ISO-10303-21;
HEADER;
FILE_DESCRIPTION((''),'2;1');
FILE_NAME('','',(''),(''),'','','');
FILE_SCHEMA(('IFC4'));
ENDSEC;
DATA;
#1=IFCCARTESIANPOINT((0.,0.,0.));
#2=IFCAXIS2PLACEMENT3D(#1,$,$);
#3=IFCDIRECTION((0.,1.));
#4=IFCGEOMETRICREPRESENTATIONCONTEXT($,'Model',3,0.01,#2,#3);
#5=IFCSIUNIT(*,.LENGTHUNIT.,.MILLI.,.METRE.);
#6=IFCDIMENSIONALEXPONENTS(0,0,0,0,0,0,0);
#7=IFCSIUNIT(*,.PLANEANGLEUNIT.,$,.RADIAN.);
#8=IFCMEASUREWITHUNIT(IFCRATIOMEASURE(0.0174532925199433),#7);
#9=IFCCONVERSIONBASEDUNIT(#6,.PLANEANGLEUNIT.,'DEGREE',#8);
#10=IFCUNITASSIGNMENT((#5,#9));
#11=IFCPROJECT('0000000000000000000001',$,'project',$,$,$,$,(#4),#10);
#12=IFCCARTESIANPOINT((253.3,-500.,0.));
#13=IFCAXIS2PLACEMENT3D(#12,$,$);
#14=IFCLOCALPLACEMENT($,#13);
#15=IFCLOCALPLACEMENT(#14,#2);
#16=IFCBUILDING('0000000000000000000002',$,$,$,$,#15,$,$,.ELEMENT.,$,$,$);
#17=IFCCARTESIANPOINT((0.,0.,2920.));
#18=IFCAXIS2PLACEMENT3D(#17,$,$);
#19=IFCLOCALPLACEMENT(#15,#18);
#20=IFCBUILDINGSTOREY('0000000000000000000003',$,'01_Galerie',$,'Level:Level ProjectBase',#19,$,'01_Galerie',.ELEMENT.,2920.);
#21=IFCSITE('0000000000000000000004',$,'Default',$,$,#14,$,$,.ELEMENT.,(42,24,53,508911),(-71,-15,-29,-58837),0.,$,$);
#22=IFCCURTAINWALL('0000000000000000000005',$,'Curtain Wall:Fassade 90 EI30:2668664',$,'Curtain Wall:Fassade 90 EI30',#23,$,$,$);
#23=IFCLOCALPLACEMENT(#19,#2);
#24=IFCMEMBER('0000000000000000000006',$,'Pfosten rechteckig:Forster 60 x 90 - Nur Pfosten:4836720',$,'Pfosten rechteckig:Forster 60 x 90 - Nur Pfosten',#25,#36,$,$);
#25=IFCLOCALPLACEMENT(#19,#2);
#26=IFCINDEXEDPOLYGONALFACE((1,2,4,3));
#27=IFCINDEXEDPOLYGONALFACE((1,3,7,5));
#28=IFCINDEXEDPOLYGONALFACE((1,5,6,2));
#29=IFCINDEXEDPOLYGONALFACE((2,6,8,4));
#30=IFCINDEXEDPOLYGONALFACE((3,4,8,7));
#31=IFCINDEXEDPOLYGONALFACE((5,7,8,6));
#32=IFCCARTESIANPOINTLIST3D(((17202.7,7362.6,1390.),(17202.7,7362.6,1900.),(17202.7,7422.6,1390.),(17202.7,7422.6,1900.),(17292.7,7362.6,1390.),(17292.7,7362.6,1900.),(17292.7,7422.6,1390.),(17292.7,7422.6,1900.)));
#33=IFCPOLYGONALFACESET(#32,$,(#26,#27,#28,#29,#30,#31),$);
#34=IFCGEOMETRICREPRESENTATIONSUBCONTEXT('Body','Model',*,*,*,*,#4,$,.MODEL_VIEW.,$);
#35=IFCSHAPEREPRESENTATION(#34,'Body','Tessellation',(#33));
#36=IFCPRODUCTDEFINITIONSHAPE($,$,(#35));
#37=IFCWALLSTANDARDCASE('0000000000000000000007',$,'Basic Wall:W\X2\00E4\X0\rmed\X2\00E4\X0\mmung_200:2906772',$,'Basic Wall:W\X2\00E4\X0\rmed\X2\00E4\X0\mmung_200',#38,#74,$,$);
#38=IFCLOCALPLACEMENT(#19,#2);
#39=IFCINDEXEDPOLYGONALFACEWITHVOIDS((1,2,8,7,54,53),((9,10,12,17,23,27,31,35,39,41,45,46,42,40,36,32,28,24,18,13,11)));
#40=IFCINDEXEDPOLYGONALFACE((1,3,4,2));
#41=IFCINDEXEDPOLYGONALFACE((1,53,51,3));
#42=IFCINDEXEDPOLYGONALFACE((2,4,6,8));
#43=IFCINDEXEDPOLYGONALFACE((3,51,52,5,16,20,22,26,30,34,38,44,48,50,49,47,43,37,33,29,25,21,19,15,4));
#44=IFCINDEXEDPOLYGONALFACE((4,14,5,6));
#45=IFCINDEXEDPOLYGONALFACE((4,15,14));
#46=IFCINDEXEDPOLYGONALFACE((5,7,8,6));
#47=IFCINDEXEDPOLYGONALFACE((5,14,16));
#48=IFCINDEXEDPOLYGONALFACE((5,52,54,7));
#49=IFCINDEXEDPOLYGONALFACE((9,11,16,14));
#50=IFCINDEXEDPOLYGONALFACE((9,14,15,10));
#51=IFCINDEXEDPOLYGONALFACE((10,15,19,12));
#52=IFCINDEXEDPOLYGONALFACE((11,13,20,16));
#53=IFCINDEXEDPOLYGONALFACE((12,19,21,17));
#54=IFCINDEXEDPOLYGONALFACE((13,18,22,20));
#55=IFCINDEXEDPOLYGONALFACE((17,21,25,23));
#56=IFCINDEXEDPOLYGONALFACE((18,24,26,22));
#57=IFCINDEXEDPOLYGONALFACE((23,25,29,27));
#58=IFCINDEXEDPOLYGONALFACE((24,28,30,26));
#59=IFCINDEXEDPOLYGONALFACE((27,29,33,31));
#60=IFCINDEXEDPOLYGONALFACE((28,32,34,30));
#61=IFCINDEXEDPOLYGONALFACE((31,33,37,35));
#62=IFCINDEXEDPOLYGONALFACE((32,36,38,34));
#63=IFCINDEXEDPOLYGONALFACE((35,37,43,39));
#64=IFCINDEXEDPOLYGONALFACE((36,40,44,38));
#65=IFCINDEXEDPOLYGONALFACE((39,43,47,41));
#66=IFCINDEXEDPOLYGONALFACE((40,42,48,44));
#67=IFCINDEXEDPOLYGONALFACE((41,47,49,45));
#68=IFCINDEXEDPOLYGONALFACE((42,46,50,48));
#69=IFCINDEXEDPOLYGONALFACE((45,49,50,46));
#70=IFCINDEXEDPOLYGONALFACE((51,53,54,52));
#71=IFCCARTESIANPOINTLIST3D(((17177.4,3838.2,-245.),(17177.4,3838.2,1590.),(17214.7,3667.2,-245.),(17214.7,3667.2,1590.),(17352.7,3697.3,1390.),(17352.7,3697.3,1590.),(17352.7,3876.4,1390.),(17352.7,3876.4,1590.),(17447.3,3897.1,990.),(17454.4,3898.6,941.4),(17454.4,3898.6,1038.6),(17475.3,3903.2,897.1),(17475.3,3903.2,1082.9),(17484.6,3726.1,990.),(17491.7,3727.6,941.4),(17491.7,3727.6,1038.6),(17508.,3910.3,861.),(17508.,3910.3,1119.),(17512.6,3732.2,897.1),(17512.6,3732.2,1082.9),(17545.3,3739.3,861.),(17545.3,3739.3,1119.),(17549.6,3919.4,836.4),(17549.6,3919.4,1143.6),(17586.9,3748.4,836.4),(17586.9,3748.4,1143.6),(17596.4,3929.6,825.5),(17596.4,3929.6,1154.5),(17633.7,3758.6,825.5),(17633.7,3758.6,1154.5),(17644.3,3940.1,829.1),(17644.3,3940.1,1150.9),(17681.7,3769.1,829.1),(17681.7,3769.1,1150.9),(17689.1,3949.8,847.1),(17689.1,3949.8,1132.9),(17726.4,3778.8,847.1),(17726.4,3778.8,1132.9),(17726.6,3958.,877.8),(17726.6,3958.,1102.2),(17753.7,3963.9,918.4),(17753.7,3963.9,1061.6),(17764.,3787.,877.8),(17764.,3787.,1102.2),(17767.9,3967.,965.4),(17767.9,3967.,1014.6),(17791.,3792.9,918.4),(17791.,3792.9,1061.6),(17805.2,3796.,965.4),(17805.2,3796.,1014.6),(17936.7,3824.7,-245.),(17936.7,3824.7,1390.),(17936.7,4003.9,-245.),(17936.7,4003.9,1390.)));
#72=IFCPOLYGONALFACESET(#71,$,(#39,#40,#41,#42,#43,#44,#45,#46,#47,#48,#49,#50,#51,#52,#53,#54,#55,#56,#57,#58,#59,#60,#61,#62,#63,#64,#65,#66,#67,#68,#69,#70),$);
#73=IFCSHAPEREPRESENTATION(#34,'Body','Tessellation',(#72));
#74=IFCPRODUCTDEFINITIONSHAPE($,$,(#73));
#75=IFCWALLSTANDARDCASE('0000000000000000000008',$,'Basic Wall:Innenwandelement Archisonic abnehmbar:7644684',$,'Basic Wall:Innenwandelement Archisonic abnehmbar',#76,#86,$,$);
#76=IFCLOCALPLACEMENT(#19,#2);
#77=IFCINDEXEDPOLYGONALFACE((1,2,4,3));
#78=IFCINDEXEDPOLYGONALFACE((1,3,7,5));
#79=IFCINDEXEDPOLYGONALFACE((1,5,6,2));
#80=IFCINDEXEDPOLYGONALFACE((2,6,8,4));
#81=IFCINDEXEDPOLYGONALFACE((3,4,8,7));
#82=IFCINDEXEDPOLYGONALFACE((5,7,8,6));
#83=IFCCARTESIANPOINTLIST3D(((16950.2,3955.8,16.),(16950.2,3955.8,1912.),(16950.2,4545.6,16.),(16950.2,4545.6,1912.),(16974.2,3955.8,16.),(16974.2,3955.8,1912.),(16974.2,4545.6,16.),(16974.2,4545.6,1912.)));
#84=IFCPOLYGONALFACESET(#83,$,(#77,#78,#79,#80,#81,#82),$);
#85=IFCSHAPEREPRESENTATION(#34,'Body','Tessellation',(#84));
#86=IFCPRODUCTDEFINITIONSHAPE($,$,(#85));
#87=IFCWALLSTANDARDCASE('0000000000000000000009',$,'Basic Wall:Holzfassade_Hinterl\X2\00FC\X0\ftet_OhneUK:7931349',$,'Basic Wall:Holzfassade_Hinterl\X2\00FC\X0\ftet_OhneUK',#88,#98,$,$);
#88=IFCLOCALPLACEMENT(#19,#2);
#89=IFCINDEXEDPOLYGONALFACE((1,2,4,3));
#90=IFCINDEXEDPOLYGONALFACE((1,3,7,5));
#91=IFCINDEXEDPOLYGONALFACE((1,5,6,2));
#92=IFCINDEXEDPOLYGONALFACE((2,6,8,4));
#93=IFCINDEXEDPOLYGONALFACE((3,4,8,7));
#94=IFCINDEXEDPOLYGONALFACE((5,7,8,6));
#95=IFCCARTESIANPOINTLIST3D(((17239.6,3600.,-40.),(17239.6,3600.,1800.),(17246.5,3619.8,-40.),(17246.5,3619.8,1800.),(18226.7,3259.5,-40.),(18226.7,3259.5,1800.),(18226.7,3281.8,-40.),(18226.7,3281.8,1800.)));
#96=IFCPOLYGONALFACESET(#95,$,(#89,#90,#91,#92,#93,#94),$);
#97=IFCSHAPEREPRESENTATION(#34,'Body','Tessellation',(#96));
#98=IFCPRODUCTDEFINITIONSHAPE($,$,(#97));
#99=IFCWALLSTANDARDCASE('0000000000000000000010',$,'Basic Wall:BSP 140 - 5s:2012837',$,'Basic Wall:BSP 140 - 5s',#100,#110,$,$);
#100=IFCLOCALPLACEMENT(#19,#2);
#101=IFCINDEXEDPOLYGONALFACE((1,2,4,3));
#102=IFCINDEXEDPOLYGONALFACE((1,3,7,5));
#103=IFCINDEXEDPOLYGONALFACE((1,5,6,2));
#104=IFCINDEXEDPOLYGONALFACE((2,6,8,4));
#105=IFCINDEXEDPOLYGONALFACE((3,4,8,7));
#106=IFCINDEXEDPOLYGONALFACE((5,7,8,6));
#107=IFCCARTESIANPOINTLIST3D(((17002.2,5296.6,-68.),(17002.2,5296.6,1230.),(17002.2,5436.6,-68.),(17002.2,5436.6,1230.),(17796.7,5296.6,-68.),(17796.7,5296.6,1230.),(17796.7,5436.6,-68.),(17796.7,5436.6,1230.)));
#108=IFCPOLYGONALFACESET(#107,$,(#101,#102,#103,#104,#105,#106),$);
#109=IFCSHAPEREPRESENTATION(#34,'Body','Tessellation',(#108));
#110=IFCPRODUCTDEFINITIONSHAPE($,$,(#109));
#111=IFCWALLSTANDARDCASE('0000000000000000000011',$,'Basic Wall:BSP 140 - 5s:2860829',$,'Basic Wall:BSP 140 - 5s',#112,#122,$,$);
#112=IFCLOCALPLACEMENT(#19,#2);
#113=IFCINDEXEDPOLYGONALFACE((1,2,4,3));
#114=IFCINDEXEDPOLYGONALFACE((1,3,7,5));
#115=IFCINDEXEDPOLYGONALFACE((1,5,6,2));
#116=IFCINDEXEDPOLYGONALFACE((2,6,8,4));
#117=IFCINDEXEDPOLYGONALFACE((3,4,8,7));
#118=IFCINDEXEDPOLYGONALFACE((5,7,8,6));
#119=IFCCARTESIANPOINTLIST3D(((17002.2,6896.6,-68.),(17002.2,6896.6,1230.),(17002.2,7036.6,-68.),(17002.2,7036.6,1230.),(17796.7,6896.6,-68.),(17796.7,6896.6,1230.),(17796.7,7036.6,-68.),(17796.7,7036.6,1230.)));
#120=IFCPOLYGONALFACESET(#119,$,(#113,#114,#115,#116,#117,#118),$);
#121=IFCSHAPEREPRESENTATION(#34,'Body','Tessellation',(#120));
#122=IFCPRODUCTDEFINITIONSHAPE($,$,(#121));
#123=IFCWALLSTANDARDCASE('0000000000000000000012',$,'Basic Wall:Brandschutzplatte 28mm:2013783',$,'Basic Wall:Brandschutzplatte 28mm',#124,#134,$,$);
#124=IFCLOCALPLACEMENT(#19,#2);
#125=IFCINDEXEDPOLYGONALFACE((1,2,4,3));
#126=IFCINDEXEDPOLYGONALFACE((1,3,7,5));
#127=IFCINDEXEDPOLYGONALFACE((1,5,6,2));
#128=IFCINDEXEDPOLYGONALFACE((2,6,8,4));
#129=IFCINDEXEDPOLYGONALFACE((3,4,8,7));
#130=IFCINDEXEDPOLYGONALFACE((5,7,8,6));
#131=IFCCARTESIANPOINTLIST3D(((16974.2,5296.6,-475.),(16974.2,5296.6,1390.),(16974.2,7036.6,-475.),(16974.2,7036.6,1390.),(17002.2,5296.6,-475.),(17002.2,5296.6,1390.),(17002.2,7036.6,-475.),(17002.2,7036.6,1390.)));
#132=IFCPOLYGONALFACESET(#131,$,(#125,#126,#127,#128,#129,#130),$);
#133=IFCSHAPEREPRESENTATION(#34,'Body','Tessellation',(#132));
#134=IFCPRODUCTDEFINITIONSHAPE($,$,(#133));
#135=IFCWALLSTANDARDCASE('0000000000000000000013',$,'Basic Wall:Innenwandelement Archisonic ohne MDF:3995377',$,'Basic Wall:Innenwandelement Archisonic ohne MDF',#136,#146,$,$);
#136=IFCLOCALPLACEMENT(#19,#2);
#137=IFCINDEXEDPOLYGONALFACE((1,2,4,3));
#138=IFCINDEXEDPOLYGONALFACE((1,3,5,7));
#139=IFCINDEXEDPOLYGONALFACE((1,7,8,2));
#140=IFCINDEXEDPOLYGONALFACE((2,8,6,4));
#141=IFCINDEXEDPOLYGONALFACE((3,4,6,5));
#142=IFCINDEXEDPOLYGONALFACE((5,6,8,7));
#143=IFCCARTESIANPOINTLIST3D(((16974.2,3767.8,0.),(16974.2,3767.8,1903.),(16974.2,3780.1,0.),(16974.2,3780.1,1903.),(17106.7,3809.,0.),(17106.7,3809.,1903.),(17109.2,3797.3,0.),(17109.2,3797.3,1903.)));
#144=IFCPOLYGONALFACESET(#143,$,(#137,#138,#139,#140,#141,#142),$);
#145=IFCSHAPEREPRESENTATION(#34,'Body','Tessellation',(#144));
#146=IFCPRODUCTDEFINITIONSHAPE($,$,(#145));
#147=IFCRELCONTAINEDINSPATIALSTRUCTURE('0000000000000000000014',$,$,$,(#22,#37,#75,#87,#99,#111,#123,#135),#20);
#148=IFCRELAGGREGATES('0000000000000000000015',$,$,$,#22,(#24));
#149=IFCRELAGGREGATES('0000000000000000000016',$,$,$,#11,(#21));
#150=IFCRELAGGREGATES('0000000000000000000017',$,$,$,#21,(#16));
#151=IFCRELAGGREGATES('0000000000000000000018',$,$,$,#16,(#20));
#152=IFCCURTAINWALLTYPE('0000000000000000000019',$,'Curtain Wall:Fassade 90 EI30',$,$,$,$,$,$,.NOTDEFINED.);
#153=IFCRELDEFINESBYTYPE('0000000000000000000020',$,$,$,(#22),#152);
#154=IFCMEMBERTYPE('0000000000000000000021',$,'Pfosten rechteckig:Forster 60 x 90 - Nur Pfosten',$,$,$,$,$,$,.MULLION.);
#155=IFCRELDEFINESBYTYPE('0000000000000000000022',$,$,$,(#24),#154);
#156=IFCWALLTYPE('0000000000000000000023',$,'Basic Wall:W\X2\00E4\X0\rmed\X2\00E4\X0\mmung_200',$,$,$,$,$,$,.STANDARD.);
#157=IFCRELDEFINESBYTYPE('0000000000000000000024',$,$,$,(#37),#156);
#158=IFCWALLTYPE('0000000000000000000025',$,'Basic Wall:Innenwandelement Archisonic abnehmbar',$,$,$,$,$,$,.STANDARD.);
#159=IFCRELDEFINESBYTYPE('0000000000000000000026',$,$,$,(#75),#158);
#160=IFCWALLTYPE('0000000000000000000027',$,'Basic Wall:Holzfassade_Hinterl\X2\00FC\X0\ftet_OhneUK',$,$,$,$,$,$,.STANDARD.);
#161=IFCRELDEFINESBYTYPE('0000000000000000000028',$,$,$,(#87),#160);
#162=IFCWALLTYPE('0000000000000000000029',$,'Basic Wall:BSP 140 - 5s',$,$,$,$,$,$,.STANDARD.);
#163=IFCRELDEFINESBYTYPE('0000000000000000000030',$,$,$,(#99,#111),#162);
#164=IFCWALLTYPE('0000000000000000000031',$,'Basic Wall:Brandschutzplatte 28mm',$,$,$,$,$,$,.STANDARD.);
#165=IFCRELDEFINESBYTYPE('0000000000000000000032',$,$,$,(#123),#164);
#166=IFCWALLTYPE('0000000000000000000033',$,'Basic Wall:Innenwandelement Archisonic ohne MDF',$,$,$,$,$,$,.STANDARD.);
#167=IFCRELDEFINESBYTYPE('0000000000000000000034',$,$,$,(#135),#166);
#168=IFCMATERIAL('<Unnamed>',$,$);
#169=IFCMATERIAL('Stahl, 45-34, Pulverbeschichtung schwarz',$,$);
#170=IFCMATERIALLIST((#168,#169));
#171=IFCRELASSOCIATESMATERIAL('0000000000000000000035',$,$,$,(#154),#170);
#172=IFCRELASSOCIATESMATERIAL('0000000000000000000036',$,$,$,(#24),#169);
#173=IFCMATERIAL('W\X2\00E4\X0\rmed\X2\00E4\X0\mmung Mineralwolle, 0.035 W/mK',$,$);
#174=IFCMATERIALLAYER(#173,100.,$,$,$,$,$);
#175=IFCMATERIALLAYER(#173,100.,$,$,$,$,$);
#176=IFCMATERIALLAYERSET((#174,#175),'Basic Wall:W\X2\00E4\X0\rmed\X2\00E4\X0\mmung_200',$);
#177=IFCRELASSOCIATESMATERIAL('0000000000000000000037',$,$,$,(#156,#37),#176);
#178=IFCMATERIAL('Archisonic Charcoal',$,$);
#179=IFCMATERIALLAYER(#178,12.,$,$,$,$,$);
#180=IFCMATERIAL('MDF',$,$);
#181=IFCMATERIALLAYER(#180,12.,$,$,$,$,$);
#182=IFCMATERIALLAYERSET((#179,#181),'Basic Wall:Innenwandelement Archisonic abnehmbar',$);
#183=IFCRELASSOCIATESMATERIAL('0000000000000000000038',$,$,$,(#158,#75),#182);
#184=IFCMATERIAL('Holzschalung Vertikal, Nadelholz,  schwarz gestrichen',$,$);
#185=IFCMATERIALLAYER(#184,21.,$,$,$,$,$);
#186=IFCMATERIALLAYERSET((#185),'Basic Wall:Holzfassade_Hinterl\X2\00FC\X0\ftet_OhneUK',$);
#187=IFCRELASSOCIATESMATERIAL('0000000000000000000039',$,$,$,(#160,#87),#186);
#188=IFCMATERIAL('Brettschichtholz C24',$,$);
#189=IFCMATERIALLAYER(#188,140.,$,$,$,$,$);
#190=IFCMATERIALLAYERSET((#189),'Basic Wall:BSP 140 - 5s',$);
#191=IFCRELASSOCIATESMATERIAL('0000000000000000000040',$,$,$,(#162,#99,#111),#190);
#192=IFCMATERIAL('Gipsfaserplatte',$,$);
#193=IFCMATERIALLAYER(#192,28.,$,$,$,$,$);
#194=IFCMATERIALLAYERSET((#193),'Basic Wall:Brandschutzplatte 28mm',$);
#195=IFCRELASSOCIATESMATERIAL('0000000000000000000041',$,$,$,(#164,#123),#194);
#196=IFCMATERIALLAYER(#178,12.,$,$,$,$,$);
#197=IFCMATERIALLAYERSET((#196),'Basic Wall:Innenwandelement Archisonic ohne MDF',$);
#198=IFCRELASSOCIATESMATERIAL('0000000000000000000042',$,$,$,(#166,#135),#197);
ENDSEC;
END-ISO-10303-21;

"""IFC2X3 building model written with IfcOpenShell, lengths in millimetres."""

from ifc_helpers import new_model, entity, si_unit, converted_unit, direction, frame, frame_2d, origin, origin_2d_with_axis, place, context, subcontext, project, spatial, polyline, rectangle, circle, outline, extrude, clip, bounded_halfspace, source, transform, mapped, material, material_list, layer, layer_set, layer_usage, type_object, type_shapes, element, aggregate, save


model = new_model("IFC2X3")

# Units and contexts
model_context = context("Model", 3, precision=0.01, world=origin(), true_north=direction((0.0, 1.0)))
body_context = subcontext(model_context, "Body", "Model", "MODEL_VIEW")
ifc_project = project(units=[si_unit("LENGTHUNIT", "METRE", prefix="MILLI"), converted_unit("PLANEANGLEUNIT", "DEGREE", entity("IfcRatioMeasure", 0.0174532925199433), si_unit("PLANEANGLEUNIT", "RADIAN"), dimensions=[0, 0, 0, 0, 0, 0, 0])], contexts=[model_context])

# Site, building, storey
site_placement = place(None, frame((253.3, -500.0, 0.0)))
site = spatial("IfcSite", under=ifc_project, at=site_placement, Name="Default", CompositionType="ELEMENT", RefLatitude=(42, 24, 53, 508911), RefLongitude=(-71, -15, -29, -58837), RefElevation=0.0)
building_placement = place(site_placement, origin())
building = spatial("IfcBuilding", under=site, at=building_placement, CompositionType="ELEMENT")
storey_placement = place(building_placement, frame((0.0, 0.0, 2920.0)))
storey = spatial("IfcBuildingStorey", under=building, at=storey_placement, Name="01_Galerie", ObjectType="Level:Level ProjectBase", LongName="01_Galerie", CompositionType="ELEMENT", Elevation=2920.0)

# Curtain wall, member
curtain_wall_type = type_object("IfcCurtainWallType", Name="Curtain Wall:Fassade 90 EI30", PredefinedType="NOTDEFINED")
curtain_wall_placement = place(storey_placement, frame((0.0, 0.0, -2920.0)))
curtain_wall = element("IfcCurtainWall", 1, at=curtain_wall_placement, inside=storey, type_object=curtain_wall_type, Name="Curtain Wall:Fassade 90 EI30:2668664", ObjectType="Curtain Wall:Fassade 90 EI30")
ifc_material_1 = material(Name="Stahl, 45-34, Pulverbeschichtung schwarz")
ifc_material_2 = material(Name="<Unnamed>")
ifc_material_list = material_list([ifc_material_2, ifc_material_1])
member_type = type_object("IfcMemberType", Name="Pfosten rechteckig:Forster 60 x 90 - Nur Pfosten", PredefinedType="MULLION", material=ifc_material_list)
shared_shape_1 = source(origin(), body_context, "Body", "SweptSolid", [
    extrude(rectangle(XDim=90.0, YDim=60.0, at=origin_2d_with_axis()), frame((0.0, 79.0, -510.0), z_axis=(0.0, 0.0, 1.0), x_axis=(0.0, -1.0, 0.0)), (0.0, 0.0, 1.0), 510.0),
])
type_shapes(member_type, [shared_shape_1])
member_placement = place(storey_placement, frame((17326.7, 7392.6, 1390.0), z_axis=(0.0, 0.0, -1.0), x_axis=(0.0, -1.0, 0.0)))
member = element("IfcMember", 2, at=member_placement, type_object=member_type, material=ifc_material_1, Name="Pfosten rechteckig:Forster 60 x 90 - Nur Pfosten:4836720", ObjectType="Pfosten rechteckig:Forster 60 x 90 - Nur Pfosten", context=body_context, shape_type="MappedRepresentation", body=[
    mapped(shared_shape_1, transform((0.0, 0.0, 0.0), scale=1.0)),
])
aggregate(curtain_wall, [member])

# Wall, openings
ifc_material_3 = material(Name="Wärmedämmung Mineralwolle, 0.035 W/mK")
ifc_layer_1 = layer(ifc_material_3, 100.0)
ifc_layer_2 = layer(ifc_material_3, 100.0)
ifc_layer_set_1 = layer_set([ifc_layer_1, ifc_layer_2], Name="Basic Wall:Wärmedämmung_200")
ifc_layer_usage_1 = layer_usage(ifc_layer_set_1, "AXIS2", "NEGATIVE", 100.0)
wall_type_1 = type_object("IfcWallType", Name="Basic Wall:Wärmedämmung_200", PredefinedType="STANDARD", material=ifc_layer_set_1)
wall_1_placement = place(storey_placement, frame((17958.0, 3906.2, -245.0), z_axis=(0.0, 0.0, 1.0), x_axis=(-0.977008, -0.213201, 0.0)))
wall_1 = element("IfcWallStandardCase", 3, at=wall_1_placement, inside=storey, type_object=wall_type_1, material=ifc_layer_usage_1, Name="Basic Wall:Wärmedämmung_200:2906772", ObjectType="Basic Wall:Wärmedämmung_200", context=body_context, shape_type="Clipping", body=[
    clip(clip(clip(clip(extrude(outline(polyline([(777.1, -100.0), (777.1, 75.0), (38.2, 75.1), (0.0, -100.0), (777.1, -100.0)])), origin(), (0.0, 0.0, 1.0), 1835.0), bounded_halfspace(frame((777.1, 75.0, 0.0), z_axis=(-0.000101, -1.0, 0.0), x_axis=(1.0, -0.000101, 0.0)), True, frame((777.1, 75.0, 0.0), z_axis=(-0.000101, -1.0, 0.0), x_axis=(1.0, -0.000101, 0.0)), polyline([(0.0, 0.0), (0.0, 245.0), (-738.9, 245.0), (-738.9, 0.0), (0.0, 0.0)]))), bounded_halfspace(frame((43.6, 100.0, 245.0), z_axis=(0.0, 0.0, 1.0), x_axis=(-0.000101, -1.0, 0.0)), True, frame((43.6, 100.0, 245.0), z_axis=(0.0, 0.0, 1.0), x_axis=(-0.000101, -1.0, 0.0)), polyline([(0.0, 0.0), (24.9, -5.4), (24.9, 733.5), (-0.1, 733.5), (0.0, 0.0)]))), bounded_halfspace(frame((597.7, -100.0, 1635.0), z_axis=(0.0, 0.0, -1.0), x_axis=(-0.835636, -0.549284, 0.0)), True, frame((597.7, -100.0, 1635.0), z_axis=(0.0, 0.0, -1.0), x_axis=(-0.835636, -0.549284, 0.0)), polyline([(0.0, 0.0), (499.5, 328.3), (353.2, 471.5), (-146.3, 143.2), (0.0, 0.0)]))), bounded_halfspace(frame((641.4, 100.0, 1635.0), z_axis=(0.977008, -0.213201, 0.0), x_axis=(0.0, 0.0, 1.0)), True, frame((641.4, 100.0, 1635.0), z_axis=(0.977008, -0.213201, 0.0), x_axis=(0.0, 0.0, 1.0)), polyline([(0.0, 0.0), (200.0, 0.0), (200.0, 204.7), (0.0, 204.7), (0.0, 0.0)]))),
])
opening_1_placement = place(wall_1_placement, frame((608.3, 120.5, 1068.4)))
element("IfcOpeningElement", 4, at=opening_1_placement, cuts=wall_1, ObjectType="Opening", context=body_context, shape_type="SweptSolid", body=[
    extrude(circle(Radius=165.0, at=frame_2d((0.0, 0.0), x_axis=(1.0, 0.0))), frame((-272.4, -484.5, 166.6), z_axis=(0.0, 1.0, 0.0), x_axis=(1.0, 0.0, 0.0)), (0.0, 0.0, 1.0), 506.3),
])
opening_2_placement = place(wall_1_placement, frame((1041.6, -52.4, 245.0)))
element("IfcOpeningElement", 5, at=opening_2_placement, cuts=wall_1, ObjectType="Opening", context=body_context, shape_type="SweptSolid", body=[
    extrude(rectangle(XDim=3000.0, YDim=45.0, at=frame_2d((0.0, 0.0), x_axis=(1.0, 0.0))), frame((-67.8, -205.3, 1500.0), z_axis=(0.213201, 0.977008, 0.0), x_axis=(0.0, 0.0, -1.0)), (0.0, 0.0, 1.0), 215.0),
])

# Walls
ifc_material_4 = material(Name="Archisonic Charcoal")
ifc_layer_3 = layer(ifc_material_4, 12.0)
ifc_material_5 = material(Name="MDF")
ifc_layer_4 = layer(ifc_material_5, 12.0)
ifc_layer_set_2 = layer_set([ifc_layer_3, ifc_layer_4], Name="Basic Wall:Innenwandelement Archisonic abnehmbar")
ifc_layer_usage_2 = layer_usage(ifc_layer_set_2, "AXIS2", "POSITIVE", -12.0)
wall_type_2 = type_object("IfcWallType", Name="Basic Wall:Innenwandelement Archisonic abnehmbar", PredefinedType="STANDARD", material=ifc_layer_set_2)
wall_2_placement = place(storey_placement, frame((16962.2, 4545.6, 16.0), z_axis=(0.0, 0.0, 1.0), x_axis=(0.0, -1.0, 0.0)))
element("IfcWallStandardCase", 6, at=wall_2_placement, inside=storey, type_object=wall_type_2, material=ifc_layer_usage_2, Name="Basic Wall:Innenwandelement Archisonic abnehmbar:7644684", ObjectType="Basic Wall:Innenwandelement Archisonic abnehmbar", context=body_context, shape_type="SweptSolid", body=[
    extrude(rectangle(XDim=589.8, YDim=24.0, at=frame_2d((294.9, 0.0), x_axis=(-1.0, 0.0))), origin(), (0.0, 0.0, 1.0), 1896.0),
])
ifc_material_6 = material(Name="Holzschalung Vertikal, Nadelholz,  schwarz gestrichen")
ifc_layer_5 = layer(ifc_material_6, 21.0)
ifc_layer_set_3 = layer_set([ifc_layer_5], Name="Basic Wall:Holzfassade_Hinterlüftet_OhneUK")
ifc_layer_usage_3 = layer_usage(ifc_layer_set_3, "AXIS2", "NEGATIVE", 10.5)
wall_type_3 = type_object("IfcWallType", Name="Basic Wall:Holzfassade_Hinterlüftet_OhneUK", PredefinedType="STANDARD", material=ifc_layer_set_3)
wall_3_placement = place(storey_placement, frame((18230.1, 3269.5, -40.0), z_axis=(0.0, 0.0, 1.0), x_axis=(-0.945352, 0.326052, 0.0)))
element("IfcWallStandardCase", 7, at=wall_3_placement, inside=storey, type_object=wall_type_3, material=ifc_layer_usage_3, Name="Basic Wall:Holzfassade_Hinterlüftet_OhneUK:7931349", ObjectType="Basic Wall:Holzfassade_Hinterlüftet_OhneUK", context=body_context, shape_type="SweptSolid", body=[
    extrude(outline(polyline([(1044.1, -10.5), (1044.1, 10.5), (0.0, 10.5), (7.2, -10.5), (1044.1, -10.5)])), origin(), (0.0, 0.0, 1.0), 1840.0),
])
ifc_material_7 = material(Name="Brettschichtholz C24")
ifc_layer_6 = layer(ifc_material_7, 140.0)
ifc_layer_set_4 = layer_set([ifc_layer_6], Name="Basic Wall:BSP 140 - 5s")
ifc_layer_usage_4 = layer_usage(ifc_layer_set_4, "AXIS2", "POSITIVE", -70.0)
wall_type_4 = type_object("IfcWallType", Name="Basic Wall:BSP 140 - 5s", PredefinedType="STANDARD", material=ifc_layer_set_4)
wall_4_placement = place(storey_placement, frame((17796.7, 5366.6, -68.0), z_axis=(0.0, 0.0, 1.0), x_axis=(-1.0, 0.0, 0.0)))
element("IfcWallStandardCase", 8, at=wall_4_placement, inside=storey, type_object=wall_type_4, material=ifc_layer_usage_4, Name="Basic Wall:BSP 140 - 5s:2012837", ObjectType="Basic Wall:BSP 140 - 5s", context=body_context, shape_type="Clipping", body=[
    clip(extrude(rectangle(XDim=794.5, YDim=140.0, at=frame_2d((397.2, 0.0), x_axis=(-1.0, 0.0))), origin(), (0.0, 0.0, 1.0), 1298.0), bounded_halfspace(frame((794.5, -70.0, 1298.0), z_axis=(-1.0, 0.0, 0.0), x_axis=(0.0, -1.0, 0.0)), True, frame((794.5, -70.0, 1298.0), z_axis=(-1.0, 0.0, 0.0), x_axis=(0.0, -1.0, 0.0)), polyline([(0.0, 0.0), (-140.0, 0.0), (-140.0, -1298.0), (0.0, -1298.0), (0.0, 0.0)]))),
])
ifc_layer_usage_5 = layer_usage(ifc_layer_set_4, "AXIS2", "POSITIVE", -70.0)
wall_5_placement = place(storey_placement, frame((17796.7, 6966.6, -68.0), z_axis=(0.0, 0.0, 1.0), x_axis=(-1.0, 0.0, 0.0)))
element("IfcWallStandardCase", 9, at=wall_5_placement, inside=storey, type_object=wall_type_4, material=ifc_layer_usage_5, Name="Basic Wall:BSP 140 - 5s:2860829", ObjectType="Basic Wall:BSP 140 - 5s", context=body_context, shape_type="Clipping", body=[
    clip(extrude(rectangle(XDim=794.5, YDim=140.0, at=frame_2d((397.2, 0.0), x_axis=(-1.0, 0.0))), origin(), (0.0, 0.0, 1.0), 1298.0), bounded_halfspace(frame((794.5, -70.0, 1298.0), z_axis=(-1.0, 0.0, 0.0), x_axis=(0.0, -1.0, 0.0)), True, frame((794.5, -70.0, 1298.0), z_axis=(-1.0, 0.0, 0.0), x_axis=(0.0, -1.0, 0.0)), polyline([(0.0, 0.0), (-140.0, 0.0), (-140.0, -1298.0), (0.0, -1298.0), (0.0, 0.0)]))),
])
ifc_material_8 = material(Name="Gipsfaserplatte")
ifc_layer_7 = layer(ifc_material_8, 28.0)
ifc_layer_set_5 = layer_set([ifc_layer_7], Name="Basic Wall:Brandschutzplatte 28mm")
ifc_layer_usage_6 = layer_usage(ifc_layer_set_5, "AXIS2", "NEGATIVE", 14.0)
wall_type_5 = type_object("IfcWallType", Name="Basic Wall:Brandschutzplatte 28mm", PredefinedType="STANDARD", material=ifc_layer_set_5)
wall_6_placement = place(storey_placement, frame((16988.2, 7036.6, -475.0), z_axis=(0.0, 0.0, 1.0), x_axis=(0.0, -1.0, 0.0)))
element("IfcWallStandardCase", 10, at=wall_6_placement, inside=storey, type_object=wall_type_5, material=ifc_layer_usage_6, Name="Basic Wall:Brandschutzplatte 28mm:2013783", ObjectType="Basic Wall:Brandschutzplatte 28mm", context=body_context, shape_type="SweptSolid", body=[
    extrude(rectangle(XDim=1740.0, YDim=28.0, at=frame_2d((870.0, 0.0), x_axis=(-1.0, 0.0))), origin(), (0.0, 0.0, 1.0), 1865.0),
])

# Wall, opening
ifc_layer_8 = layer(ifc_material_4, 12.0)
ifc_layer_set_6 = layer_set([ifc_layer_8], Name="Basic Wall:Innenwandelement Archisonic ohne MDF")
ifc_layer_usage_7 = layer_usage(ifc_layer_set_6, "AXIS2", "NEGATIVE", 6.0)
wall_type_6 = type_object("IfcWallType", Name="Basic Wall:Innenwandelement Archisonic ohne MDF", PredefinedType="STANDARD", material=ifc_layer_set_6)
wall_7_placement = place(storey_placement, frame((17108.0, 3803.1, 0.0), z_axis=(0.0, 0.0, 1.0), x_axis=(-0.977008, -0.213201, 0.0)))
wall_7 = element("IfcWallStandardCase", 11, at=wall_7_placement, inside=storey, type_object=wall_type_6, material=ifc_layer_usage_7, Name="Basic Wall:Innenwandelement Archisonic ohne MDF:3995377", ObjectType="Basic Wall:Innenwandelement Archisonic ohne MDF", context=body_context, shape_type="Clipping", body=[
    clip(extrude(outline(polyline([(135.6, -6.0), (138.3, 6.0), (0.0, 6.0), (0.0, -6.0), (135.6, -6.0)])), origin(), (0.0, 0.0, 1.0), 1903.0), bounded_halfspace(frame((0.0, -6.0, 1903.0), z_axis=(0.0, 0.0, -1.0), x_axis=(-0.213201, -0.977008, 0.0)), True, frame((0.0, -6.0, 1903.0)), polyline([(0.0, 0.0), (135.6, 0.0), (138.3, 12.0), (0.0, 12.0), (0.0, 0.0)]))),
])
opening_3_placement = place(wall_7_placement, frame((189.1, 28.1, 0.0)))
element("IfcOpeningElement", 12, at=opening_3_placement, cuts=wall_7, ObjectType="Opening", context=body_context, shape_type="SweptSolid", body=[
    extrude(rectangle(XDim=3000.0, YDim=45.0, at=frame_2d((0.0, 0.0), x_axis=(1.0, 0.0))), frame((-67.8, -205.3, 1500.0), z_axis=(0.213201, 0.977008, 0.0), x_axis=(0.0, 0.0, -1.0)), (0.0, 0.0, 1.0), 215.0),
])

save(model, "model.ifc")
